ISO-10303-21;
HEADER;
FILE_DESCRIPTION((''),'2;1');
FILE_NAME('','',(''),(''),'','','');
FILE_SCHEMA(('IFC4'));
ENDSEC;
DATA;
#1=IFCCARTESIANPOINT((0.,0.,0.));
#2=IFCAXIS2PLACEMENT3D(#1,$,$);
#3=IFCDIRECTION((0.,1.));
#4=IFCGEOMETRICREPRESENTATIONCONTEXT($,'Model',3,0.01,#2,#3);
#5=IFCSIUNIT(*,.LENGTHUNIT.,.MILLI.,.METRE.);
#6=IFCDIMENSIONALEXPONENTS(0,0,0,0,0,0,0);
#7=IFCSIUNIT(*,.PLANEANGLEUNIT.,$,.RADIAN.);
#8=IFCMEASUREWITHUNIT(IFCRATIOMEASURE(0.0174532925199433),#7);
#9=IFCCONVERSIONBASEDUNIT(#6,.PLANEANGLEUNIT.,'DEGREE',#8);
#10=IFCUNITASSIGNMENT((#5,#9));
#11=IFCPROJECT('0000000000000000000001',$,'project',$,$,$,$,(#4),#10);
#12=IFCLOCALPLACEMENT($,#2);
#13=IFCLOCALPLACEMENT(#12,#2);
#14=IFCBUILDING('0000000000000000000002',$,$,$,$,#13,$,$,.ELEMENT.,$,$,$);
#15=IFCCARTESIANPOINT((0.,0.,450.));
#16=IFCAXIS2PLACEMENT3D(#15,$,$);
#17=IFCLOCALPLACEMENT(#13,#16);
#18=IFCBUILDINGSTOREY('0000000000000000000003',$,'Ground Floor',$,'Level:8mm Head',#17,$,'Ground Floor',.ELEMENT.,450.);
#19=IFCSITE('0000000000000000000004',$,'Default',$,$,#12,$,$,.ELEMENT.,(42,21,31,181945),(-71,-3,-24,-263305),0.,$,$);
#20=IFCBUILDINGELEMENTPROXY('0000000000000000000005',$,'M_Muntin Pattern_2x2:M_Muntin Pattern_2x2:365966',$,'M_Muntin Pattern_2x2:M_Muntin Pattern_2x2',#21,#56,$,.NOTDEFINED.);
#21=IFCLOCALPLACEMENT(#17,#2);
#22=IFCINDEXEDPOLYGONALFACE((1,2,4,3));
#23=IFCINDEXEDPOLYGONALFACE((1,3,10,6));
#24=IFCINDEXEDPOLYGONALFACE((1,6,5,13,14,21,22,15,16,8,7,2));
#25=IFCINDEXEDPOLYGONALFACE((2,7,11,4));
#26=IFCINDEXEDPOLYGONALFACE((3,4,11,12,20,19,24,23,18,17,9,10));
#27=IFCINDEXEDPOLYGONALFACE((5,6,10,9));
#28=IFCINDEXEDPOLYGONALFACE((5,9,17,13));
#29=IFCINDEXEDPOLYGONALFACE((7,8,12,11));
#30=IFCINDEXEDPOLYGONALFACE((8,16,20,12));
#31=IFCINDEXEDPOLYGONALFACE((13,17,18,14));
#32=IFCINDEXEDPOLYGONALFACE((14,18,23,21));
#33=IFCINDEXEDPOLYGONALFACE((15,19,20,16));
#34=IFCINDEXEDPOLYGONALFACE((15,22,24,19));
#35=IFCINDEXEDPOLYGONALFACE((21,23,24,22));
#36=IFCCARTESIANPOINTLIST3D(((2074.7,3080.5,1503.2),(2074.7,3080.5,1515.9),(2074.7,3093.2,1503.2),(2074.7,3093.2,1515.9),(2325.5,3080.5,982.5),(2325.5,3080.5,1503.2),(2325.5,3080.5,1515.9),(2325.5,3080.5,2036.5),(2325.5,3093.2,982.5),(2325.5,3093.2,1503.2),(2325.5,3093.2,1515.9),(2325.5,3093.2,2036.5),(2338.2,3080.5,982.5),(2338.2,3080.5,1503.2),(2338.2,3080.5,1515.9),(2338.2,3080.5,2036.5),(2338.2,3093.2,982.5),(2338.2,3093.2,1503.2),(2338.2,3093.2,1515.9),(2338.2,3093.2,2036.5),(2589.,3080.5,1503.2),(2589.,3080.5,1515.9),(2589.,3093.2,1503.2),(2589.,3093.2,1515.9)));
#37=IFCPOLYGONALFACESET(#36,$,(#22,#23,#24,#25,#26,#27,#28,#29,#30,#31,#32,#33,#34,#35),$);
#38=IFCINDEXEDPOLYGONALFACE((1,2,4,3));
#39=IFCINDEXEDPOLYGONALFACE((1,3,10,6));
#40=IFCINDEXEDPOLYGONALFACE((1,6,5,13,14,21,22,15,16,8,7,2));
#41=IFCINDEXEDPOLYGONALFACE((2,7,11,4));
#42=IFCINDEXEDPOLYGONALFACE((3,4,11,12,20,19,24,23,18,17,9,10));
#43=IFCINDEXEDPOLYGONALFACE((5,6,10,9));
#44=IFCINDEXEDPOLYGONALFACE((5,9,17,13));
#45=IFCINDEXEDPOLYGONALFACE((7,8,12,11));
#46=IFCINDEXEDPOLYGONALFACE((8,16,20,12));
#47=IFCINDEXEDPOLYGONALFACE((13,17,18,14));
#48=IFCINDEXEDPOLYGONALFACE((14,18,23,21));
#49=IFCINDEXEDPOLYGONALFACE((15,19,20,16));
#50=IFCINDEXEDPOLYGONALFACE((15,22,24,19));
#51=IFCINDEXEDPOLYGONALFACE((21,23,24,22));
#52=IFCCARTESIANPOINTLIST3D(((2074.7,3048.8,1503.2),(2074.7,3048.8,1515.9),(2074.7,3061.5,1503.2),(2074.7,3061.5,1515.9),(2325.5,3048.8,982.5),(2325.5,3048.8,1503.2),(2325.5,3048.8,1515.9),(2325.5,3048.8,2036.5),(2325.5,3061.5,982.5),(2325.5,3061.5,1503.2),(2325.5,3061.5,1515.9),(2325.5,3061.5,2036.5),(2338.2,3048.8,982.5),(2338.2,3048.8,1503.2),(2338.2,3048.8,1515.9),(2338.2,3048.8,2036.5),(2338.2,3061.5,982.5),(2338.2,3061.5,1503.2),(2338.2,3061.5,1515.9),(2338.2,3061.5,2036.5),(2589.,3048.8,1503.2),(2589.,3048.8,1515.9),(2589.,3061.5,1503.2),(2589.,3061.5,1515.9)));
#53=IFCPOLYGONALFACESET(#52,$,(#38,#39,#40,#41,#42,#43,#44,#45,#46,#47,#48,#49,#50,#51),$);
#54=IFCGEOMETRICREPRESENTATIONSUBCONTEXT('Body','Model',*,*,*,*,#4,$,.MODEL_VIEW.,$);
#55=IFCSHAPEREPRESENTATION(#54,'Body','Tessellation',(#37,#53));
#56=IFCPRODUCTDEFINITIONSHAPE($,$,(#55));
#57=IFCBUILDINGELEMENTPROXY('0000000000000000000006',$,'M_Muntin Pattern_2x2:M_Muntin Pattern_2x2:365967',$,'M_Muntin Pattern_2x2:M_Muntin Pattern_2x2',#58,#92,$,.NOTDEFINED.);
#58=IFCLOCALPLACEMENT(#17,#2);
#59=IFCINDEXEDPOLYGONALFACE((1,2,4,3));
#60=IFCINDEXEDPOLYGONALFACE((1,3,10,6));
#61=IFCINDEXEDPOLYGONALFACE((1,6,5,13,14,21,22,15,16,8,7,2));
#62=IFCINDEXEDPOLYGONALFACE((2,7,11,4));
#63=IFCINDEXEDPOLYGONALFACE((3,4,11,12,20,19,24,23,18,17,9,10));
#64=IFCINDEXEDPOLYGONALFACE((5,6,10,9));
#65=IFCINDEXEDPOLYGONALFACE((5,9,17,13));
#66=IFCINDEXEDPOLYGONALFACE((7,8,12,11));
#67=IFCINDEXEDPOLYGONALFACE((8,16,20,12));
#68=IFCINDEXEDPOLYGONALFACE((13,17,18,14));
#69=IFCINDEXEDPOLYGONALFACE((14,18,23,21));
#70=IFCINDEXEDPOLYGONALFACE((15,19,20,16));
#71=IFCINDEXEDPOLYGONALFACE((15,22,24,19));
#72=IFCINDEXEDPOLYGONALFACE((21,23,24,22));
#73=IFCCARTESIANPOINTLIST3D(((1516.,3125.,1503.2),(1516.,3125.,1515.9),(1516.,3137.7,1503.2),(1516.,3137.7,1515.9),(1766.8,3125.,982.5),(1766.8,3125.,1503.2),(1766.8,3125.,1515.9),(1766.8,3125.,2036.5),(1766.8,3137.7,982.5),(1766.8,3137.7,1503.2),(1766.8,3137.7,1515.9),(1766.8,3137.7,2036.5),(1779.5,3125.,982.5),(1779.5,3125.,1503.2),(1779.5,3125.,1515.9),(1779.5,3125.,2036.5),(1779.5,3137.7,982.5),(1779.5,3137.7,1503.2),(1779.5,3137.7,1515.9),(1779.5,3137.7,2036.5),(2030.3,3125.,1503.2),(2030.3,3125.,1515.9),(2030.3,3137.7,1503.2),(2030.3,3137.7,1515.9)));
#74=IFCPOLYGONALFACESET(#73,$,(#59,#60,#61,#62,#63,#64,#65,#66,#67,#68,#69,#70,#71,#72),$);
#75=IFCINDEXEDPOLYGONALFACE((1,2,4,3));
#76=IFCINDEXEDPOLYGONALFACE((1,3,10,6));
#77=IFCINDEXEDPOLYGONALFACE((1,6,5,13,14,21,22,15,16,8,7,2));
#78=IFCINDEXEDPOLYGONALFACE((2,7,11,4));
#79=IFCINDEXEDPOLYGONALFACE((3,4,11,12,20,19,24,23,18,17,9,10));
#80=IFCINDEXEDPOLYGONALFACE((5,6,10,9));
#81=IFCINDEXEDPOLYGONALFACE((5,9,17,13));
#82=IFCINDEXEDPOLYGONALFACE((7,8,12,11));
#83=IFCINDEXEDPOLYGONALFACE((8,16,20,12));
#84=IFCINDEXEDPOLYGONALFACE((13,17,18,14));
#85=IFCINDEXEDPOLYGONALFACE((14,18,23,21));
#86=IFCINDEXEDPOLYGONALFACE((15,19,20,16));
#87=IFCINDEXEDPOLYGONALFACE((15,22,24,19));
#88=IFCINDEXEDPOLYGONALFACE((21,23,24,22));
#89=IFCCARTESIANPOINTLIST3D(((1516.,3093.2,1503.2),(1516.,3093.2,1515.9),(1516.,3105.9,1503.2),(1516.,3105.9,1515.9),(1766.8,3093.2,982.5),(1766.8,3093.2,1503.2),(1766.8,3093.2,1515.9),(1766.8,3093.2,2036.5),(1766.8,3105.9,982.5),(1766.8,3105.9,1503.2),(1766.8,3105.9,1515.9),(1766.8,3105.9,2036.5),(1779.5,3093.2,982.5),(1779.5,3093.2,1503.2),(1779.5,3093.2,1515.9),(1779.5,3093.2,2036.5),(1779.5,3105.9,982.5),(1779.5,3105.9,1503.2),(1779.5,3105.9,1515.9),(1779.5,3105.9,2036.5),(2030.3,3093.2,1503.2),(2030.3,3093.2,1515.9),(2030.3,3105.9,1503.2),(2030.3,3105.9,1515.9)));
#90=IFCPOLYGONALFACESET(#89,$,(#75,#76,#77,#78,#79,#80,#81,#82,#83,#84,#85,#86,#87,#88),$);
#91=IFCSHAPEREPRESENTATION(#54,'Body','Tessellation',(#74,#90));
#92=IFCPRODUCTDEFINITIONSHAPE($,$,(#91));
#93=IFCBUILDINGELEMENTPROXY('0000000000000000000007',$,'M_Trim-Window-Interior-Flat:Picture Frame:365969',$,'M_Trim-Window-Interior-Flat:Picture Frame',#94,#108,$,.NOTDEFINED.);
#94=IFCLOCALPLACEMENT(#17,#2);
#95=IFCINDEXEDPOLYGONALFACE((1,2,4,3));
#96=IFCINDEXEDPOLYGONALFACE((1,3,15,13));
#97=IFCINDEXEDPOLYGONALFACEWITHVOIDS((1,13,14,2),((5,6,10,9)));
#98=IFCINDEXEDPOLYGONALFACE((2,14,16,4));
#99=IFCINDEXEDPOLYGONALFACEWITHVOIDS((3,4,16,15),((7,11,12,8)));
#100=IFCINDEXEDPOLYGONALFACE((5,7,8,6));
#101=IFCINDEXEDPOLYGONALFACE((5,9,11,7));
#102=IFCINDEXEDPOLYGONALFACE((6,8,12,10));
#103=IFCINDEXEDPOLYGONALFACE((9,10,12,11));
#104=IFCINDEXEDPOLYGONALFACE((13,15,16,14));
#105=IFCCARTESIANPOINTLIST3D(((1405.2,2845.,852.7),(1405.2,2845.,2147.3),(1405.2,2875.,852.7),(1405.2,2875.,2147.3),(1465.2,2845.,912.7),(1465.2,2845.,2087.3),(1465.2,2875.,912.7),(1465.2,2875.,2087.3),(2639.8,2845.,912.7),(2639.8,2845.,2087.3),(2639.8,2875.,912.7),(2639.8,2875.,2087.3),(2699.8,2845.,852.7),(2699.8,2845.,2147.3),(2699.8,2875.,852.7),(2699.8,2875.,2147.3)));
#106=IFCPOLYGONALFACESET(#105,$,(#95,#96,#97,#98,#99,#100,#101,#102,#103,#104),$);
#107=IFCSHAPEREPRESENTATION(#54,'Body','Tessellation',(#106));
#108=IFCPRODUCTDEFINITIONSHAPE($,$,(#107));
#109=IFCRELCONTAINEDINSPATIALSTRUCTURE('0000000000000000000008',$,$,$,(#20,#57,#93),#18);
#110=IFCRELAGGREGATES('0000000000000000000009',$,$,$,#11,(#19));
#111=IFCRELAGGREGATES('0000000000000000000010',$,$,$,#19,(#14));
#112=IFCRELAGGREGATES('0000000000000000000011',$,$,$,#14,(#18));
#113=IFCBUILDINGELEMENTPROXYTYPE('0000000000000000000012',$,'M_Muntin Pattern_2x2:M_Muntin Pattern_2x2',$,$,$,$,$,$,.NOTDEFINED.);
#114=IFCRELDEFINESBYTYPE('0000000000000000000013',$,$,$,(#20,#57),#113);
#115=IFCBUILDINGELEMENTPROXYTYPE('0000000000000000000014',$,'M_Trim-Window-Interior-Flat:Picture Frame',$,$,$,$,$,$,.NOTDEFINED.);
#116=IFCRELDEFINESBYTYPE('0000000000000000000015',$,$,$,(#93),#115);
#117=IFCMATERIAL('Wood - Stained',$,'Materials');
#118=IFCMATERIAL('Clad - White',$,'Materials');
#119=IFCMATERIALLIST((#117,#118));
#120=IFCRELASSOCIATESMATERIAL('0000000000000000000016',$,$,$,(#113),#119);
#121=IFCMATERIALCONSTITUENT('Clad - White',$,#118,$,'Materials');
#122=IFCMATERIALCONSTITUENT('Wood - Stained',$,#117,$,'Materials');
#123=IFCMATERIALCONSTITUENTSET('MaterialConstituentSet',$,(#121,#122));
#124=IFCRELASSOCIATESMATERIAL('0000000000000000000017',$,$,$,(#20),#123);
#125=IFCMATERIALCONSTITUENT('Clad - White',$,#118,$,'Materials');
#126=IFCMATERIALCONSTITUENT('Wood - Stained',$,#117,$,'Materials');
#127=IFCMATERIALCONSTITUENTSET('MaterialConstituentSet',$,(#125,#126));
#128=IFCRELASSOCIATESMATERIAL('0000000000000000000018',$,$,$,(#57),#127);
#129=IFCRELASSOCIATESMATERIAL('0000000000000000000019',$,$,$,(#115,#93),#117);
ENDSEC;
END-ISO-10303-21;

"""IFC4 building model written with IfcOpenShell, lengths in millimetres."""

from ifc_helpers import new_model, entity, si_unit, converted_unit, direction, frame, origin, place, context, subcontext, project, spatial, polyline, outline, extrude, source, transform, mapped, material, material_list, constituent, constituent_set, type_object, type_shapes, element, save


model = new_model("IFC4")

# Units and contexts
model_context = context("Model", 3, precision=0.01, world=origin(), true_north=direction((0.0, 1.0)))
body_context = subcontext(model_context, "Body", "Model", "MODEL_VIEW")
ifc_project = project(units=[si_unit("LENGTHUNIT", "METRE", prefix="MILLI"), converted_unit("PLANEANGLEUNIT", "DEGREE", entity("IfcRatioMeasure", 0.0174532925199433), si_unit("PLANEANGLEUNIT", "RADIAN"), dimensions=[0, 0, 0, 0, 0, 0, 0])], contexts=[model_context])

# Site, building, storey
site_placement = place(None, origin())
site = spatial("IfcSite", under=ifc_project, at=site_placement, Name="Default", CompositionType="ELEMENT", RefLatitude=(42, 21, 31, 181945), RefLongitude=(-71, -3, -24, -263305), RefElevation=0.0)
building_placement = place(site_placement, origin())
building = spatial("IfcBuilding", under=site, at=building_placement, CompositionType="ELEMENT")
storey_placement = place(building_placement, frame((0.0, 0.0, 450.0)))
storey = spatial("IfcBuildingStorey", under=building, at=storey_placement, Name="Ground Floor", ObjectType="Level:8mm Head", LongName="Ground Floor", CompositionType="ELEMENT", Elevation=450.0)

# Building element proxies
ifc_material_1 = material(Name="Clad - White", Category="Materials")
ifc_constituent_1 = constituent(ifc_material_1, Name="Clad - White", Category="Materials")
ifc_material_2 = material(Name="Wood - Stained", Category="Materials")
ifc_constituent_2 = constituent(ifc_material_2, Name="Wood - Stained", Category="Materials")
ifc_constituent_set_1 = constituent_set(constituents=[ifc_constituent_1, ifc_constituent_2], Name="MaterialConstituentSet")
ifc_material_list = material_list([ifc_material_2, ifc_material_1])
building_element_proxy_type_1 = type_object("IfcBuildingElementProxyType", Name="M_Muntin Pattern_2x2:M_Muntin Pattern_2x2", PredefinedType="NOTDEFINED", material=ifc_material_list)
shared_shape_1 = source(origin(), body_context, "Body", "SweptSolid", [
    extrude(outline(polyline([(6.4, -6.4), (527.0, -6.4), (527.0, 6.3), (6.4, 6.3), (6.4, 257.1), (-6.3, 257.1), (-6.3, 6.3), (-527.0, 6.3), (-527.0, -6.4), (-6.3, -6.4), (-6.3, -257.1), (6.4, -257.1), (6.4, -6.4)])), frame((0.0, 9.5, 527.0), z_axis=(0.0, 1.0, 0.0), x_axis=(0.0, 0.0, 1.0)), (0.0, 0.0, 1.0), 12.7),
    extrude(outline(polyline([(6.4, -6.4), (527.0, -6.4), (527.0, 6.3), (6.4, 6.3), (6.4, 257.1), (-6.3, 257.1), (-6.3, 6.3), (-527.0, 6.3), (-527.0, -6.4), (-6.3, -6.4), (-6.3, -257.1), (6.4, -257.1), (6.4, -6.4)])), frame((0.0, -22.2, 527.0), z_axis=(0.0, 1.0, 0.0), x_axis=(0.0, 0.0, 1.0)), (0.0, 0.0, 1.0), 12.7),
])
type_shapes(building_element_proxy_type_1, [shared_shape_1])
proxy_1_placement = place(storey_placement, frame((2331.9, 3071.0, 982.5)))
element("IfcBuildingElementProxy", 1, at=proxy_1_placement, inside=storey, type_object=building_element_proxy_type_1, material=ifc_constituent_set_1, Name="M_Muntin Pattern_2x2:M_Muntin Pattern_2x2:365966", ObjectType="M_Muntin Pattern_2x2:M_Muntin Pattern_2x2", PredefinedType="NOTDEFINED", context=body_context, shape_type="MappedRepresentation", body=[
    mapped(shared_shape_1, transform((0.0, 0.0, 0.0), scale=1.0)),
])
ifc_constituent_3 = constituent(ifc_material_1, Name="Clad - White", Category="Materials")
ifc_constituent_4 = constituent(ifc_material_2, Name="Wood - Stained", Category="Materials")
ifc_constituent_set_2 = constituent_set(constituents=[ifc_constituent_3, ifc_constituent_4], Name="MaterialConstituentSet")
proxy_2_placement = place(storey_placement, frame((1773.1, 3115.5, 982.5)))
element("IfcBuildingElementProxy", 2, at=proxy_2_placement, inside=storey, type_object=building_element_proxy_type_1, material=ifc_constituent_set_2, Name="M_Muntin Pattern_2x2:M_Muntin Pattern_2x2:365967", ObjectType="M_Muntin Pattern_2x2:M_Muntin Pattern_2x2", PredefinedType="NOTDEFINED", context=body_context, shape_type="MappedRepresentation", body=[
    mapped(shared_shape_1, transform((0.0, 0.0, 0.0), scale=1.0)),
])
building_element_proxy_type_2 = type_object("IfcBuildingElementProxyType", Name="M_Trim-Window-Interior-Flat:Picture Frame", PredefinedType="NOTDEFINED", material=ifc_material_2)
shared_shape_2 = source(origin(), body_context, "Body", "SweptSolid", [
    extrude(outline(polyline([(-647.3, -647.3), (647.3, -647.3), (647.3, 647.3), (-647.3, 647.3), (-647.3, -647.3)]), holes=[polyline([(-587.3, -587.3), (-587.3, 587.3), (587.3, 587.3), (587.3, -587.3), (-587.3, -587.3)])]), frame((0.0, -600.0, 0.0), z_axis=(0.0, 0.0, 1.0), x_axis=(-1.0, 0.0, 0.0)), (0.0, 0.0, 1.0), 30.0),
])
type_shapes(building_element_proxy_type_2, [shared_shape_2])
proxy_3_placement = place(storey_placement, frame((2052.5, 2875.0, 2100.0), z_axis=(0.0, -1.0, 0.0), x_axis=(1.0, 0.0, 0.0)))
element("IfcBuildingElementProxy", 3, at=proxy_3_placement, inside=storey, type_object=building_element_proxy_type_2, material=ifc_material_2, Name="M_Trim-Window-Interior-Flat:Picture Frame:365969", ObjectType="M_Trim-Window-Interior-Flat:Picture Frame", PredefinedType="NOTDEFINED", context=body_context, shape_type="MappedRepresentation", body=[
    mapped(shared_shape_2, transform((0.0, 0.0, 0.0), scale=1.0)),
])

save(model, "model.ifc")
